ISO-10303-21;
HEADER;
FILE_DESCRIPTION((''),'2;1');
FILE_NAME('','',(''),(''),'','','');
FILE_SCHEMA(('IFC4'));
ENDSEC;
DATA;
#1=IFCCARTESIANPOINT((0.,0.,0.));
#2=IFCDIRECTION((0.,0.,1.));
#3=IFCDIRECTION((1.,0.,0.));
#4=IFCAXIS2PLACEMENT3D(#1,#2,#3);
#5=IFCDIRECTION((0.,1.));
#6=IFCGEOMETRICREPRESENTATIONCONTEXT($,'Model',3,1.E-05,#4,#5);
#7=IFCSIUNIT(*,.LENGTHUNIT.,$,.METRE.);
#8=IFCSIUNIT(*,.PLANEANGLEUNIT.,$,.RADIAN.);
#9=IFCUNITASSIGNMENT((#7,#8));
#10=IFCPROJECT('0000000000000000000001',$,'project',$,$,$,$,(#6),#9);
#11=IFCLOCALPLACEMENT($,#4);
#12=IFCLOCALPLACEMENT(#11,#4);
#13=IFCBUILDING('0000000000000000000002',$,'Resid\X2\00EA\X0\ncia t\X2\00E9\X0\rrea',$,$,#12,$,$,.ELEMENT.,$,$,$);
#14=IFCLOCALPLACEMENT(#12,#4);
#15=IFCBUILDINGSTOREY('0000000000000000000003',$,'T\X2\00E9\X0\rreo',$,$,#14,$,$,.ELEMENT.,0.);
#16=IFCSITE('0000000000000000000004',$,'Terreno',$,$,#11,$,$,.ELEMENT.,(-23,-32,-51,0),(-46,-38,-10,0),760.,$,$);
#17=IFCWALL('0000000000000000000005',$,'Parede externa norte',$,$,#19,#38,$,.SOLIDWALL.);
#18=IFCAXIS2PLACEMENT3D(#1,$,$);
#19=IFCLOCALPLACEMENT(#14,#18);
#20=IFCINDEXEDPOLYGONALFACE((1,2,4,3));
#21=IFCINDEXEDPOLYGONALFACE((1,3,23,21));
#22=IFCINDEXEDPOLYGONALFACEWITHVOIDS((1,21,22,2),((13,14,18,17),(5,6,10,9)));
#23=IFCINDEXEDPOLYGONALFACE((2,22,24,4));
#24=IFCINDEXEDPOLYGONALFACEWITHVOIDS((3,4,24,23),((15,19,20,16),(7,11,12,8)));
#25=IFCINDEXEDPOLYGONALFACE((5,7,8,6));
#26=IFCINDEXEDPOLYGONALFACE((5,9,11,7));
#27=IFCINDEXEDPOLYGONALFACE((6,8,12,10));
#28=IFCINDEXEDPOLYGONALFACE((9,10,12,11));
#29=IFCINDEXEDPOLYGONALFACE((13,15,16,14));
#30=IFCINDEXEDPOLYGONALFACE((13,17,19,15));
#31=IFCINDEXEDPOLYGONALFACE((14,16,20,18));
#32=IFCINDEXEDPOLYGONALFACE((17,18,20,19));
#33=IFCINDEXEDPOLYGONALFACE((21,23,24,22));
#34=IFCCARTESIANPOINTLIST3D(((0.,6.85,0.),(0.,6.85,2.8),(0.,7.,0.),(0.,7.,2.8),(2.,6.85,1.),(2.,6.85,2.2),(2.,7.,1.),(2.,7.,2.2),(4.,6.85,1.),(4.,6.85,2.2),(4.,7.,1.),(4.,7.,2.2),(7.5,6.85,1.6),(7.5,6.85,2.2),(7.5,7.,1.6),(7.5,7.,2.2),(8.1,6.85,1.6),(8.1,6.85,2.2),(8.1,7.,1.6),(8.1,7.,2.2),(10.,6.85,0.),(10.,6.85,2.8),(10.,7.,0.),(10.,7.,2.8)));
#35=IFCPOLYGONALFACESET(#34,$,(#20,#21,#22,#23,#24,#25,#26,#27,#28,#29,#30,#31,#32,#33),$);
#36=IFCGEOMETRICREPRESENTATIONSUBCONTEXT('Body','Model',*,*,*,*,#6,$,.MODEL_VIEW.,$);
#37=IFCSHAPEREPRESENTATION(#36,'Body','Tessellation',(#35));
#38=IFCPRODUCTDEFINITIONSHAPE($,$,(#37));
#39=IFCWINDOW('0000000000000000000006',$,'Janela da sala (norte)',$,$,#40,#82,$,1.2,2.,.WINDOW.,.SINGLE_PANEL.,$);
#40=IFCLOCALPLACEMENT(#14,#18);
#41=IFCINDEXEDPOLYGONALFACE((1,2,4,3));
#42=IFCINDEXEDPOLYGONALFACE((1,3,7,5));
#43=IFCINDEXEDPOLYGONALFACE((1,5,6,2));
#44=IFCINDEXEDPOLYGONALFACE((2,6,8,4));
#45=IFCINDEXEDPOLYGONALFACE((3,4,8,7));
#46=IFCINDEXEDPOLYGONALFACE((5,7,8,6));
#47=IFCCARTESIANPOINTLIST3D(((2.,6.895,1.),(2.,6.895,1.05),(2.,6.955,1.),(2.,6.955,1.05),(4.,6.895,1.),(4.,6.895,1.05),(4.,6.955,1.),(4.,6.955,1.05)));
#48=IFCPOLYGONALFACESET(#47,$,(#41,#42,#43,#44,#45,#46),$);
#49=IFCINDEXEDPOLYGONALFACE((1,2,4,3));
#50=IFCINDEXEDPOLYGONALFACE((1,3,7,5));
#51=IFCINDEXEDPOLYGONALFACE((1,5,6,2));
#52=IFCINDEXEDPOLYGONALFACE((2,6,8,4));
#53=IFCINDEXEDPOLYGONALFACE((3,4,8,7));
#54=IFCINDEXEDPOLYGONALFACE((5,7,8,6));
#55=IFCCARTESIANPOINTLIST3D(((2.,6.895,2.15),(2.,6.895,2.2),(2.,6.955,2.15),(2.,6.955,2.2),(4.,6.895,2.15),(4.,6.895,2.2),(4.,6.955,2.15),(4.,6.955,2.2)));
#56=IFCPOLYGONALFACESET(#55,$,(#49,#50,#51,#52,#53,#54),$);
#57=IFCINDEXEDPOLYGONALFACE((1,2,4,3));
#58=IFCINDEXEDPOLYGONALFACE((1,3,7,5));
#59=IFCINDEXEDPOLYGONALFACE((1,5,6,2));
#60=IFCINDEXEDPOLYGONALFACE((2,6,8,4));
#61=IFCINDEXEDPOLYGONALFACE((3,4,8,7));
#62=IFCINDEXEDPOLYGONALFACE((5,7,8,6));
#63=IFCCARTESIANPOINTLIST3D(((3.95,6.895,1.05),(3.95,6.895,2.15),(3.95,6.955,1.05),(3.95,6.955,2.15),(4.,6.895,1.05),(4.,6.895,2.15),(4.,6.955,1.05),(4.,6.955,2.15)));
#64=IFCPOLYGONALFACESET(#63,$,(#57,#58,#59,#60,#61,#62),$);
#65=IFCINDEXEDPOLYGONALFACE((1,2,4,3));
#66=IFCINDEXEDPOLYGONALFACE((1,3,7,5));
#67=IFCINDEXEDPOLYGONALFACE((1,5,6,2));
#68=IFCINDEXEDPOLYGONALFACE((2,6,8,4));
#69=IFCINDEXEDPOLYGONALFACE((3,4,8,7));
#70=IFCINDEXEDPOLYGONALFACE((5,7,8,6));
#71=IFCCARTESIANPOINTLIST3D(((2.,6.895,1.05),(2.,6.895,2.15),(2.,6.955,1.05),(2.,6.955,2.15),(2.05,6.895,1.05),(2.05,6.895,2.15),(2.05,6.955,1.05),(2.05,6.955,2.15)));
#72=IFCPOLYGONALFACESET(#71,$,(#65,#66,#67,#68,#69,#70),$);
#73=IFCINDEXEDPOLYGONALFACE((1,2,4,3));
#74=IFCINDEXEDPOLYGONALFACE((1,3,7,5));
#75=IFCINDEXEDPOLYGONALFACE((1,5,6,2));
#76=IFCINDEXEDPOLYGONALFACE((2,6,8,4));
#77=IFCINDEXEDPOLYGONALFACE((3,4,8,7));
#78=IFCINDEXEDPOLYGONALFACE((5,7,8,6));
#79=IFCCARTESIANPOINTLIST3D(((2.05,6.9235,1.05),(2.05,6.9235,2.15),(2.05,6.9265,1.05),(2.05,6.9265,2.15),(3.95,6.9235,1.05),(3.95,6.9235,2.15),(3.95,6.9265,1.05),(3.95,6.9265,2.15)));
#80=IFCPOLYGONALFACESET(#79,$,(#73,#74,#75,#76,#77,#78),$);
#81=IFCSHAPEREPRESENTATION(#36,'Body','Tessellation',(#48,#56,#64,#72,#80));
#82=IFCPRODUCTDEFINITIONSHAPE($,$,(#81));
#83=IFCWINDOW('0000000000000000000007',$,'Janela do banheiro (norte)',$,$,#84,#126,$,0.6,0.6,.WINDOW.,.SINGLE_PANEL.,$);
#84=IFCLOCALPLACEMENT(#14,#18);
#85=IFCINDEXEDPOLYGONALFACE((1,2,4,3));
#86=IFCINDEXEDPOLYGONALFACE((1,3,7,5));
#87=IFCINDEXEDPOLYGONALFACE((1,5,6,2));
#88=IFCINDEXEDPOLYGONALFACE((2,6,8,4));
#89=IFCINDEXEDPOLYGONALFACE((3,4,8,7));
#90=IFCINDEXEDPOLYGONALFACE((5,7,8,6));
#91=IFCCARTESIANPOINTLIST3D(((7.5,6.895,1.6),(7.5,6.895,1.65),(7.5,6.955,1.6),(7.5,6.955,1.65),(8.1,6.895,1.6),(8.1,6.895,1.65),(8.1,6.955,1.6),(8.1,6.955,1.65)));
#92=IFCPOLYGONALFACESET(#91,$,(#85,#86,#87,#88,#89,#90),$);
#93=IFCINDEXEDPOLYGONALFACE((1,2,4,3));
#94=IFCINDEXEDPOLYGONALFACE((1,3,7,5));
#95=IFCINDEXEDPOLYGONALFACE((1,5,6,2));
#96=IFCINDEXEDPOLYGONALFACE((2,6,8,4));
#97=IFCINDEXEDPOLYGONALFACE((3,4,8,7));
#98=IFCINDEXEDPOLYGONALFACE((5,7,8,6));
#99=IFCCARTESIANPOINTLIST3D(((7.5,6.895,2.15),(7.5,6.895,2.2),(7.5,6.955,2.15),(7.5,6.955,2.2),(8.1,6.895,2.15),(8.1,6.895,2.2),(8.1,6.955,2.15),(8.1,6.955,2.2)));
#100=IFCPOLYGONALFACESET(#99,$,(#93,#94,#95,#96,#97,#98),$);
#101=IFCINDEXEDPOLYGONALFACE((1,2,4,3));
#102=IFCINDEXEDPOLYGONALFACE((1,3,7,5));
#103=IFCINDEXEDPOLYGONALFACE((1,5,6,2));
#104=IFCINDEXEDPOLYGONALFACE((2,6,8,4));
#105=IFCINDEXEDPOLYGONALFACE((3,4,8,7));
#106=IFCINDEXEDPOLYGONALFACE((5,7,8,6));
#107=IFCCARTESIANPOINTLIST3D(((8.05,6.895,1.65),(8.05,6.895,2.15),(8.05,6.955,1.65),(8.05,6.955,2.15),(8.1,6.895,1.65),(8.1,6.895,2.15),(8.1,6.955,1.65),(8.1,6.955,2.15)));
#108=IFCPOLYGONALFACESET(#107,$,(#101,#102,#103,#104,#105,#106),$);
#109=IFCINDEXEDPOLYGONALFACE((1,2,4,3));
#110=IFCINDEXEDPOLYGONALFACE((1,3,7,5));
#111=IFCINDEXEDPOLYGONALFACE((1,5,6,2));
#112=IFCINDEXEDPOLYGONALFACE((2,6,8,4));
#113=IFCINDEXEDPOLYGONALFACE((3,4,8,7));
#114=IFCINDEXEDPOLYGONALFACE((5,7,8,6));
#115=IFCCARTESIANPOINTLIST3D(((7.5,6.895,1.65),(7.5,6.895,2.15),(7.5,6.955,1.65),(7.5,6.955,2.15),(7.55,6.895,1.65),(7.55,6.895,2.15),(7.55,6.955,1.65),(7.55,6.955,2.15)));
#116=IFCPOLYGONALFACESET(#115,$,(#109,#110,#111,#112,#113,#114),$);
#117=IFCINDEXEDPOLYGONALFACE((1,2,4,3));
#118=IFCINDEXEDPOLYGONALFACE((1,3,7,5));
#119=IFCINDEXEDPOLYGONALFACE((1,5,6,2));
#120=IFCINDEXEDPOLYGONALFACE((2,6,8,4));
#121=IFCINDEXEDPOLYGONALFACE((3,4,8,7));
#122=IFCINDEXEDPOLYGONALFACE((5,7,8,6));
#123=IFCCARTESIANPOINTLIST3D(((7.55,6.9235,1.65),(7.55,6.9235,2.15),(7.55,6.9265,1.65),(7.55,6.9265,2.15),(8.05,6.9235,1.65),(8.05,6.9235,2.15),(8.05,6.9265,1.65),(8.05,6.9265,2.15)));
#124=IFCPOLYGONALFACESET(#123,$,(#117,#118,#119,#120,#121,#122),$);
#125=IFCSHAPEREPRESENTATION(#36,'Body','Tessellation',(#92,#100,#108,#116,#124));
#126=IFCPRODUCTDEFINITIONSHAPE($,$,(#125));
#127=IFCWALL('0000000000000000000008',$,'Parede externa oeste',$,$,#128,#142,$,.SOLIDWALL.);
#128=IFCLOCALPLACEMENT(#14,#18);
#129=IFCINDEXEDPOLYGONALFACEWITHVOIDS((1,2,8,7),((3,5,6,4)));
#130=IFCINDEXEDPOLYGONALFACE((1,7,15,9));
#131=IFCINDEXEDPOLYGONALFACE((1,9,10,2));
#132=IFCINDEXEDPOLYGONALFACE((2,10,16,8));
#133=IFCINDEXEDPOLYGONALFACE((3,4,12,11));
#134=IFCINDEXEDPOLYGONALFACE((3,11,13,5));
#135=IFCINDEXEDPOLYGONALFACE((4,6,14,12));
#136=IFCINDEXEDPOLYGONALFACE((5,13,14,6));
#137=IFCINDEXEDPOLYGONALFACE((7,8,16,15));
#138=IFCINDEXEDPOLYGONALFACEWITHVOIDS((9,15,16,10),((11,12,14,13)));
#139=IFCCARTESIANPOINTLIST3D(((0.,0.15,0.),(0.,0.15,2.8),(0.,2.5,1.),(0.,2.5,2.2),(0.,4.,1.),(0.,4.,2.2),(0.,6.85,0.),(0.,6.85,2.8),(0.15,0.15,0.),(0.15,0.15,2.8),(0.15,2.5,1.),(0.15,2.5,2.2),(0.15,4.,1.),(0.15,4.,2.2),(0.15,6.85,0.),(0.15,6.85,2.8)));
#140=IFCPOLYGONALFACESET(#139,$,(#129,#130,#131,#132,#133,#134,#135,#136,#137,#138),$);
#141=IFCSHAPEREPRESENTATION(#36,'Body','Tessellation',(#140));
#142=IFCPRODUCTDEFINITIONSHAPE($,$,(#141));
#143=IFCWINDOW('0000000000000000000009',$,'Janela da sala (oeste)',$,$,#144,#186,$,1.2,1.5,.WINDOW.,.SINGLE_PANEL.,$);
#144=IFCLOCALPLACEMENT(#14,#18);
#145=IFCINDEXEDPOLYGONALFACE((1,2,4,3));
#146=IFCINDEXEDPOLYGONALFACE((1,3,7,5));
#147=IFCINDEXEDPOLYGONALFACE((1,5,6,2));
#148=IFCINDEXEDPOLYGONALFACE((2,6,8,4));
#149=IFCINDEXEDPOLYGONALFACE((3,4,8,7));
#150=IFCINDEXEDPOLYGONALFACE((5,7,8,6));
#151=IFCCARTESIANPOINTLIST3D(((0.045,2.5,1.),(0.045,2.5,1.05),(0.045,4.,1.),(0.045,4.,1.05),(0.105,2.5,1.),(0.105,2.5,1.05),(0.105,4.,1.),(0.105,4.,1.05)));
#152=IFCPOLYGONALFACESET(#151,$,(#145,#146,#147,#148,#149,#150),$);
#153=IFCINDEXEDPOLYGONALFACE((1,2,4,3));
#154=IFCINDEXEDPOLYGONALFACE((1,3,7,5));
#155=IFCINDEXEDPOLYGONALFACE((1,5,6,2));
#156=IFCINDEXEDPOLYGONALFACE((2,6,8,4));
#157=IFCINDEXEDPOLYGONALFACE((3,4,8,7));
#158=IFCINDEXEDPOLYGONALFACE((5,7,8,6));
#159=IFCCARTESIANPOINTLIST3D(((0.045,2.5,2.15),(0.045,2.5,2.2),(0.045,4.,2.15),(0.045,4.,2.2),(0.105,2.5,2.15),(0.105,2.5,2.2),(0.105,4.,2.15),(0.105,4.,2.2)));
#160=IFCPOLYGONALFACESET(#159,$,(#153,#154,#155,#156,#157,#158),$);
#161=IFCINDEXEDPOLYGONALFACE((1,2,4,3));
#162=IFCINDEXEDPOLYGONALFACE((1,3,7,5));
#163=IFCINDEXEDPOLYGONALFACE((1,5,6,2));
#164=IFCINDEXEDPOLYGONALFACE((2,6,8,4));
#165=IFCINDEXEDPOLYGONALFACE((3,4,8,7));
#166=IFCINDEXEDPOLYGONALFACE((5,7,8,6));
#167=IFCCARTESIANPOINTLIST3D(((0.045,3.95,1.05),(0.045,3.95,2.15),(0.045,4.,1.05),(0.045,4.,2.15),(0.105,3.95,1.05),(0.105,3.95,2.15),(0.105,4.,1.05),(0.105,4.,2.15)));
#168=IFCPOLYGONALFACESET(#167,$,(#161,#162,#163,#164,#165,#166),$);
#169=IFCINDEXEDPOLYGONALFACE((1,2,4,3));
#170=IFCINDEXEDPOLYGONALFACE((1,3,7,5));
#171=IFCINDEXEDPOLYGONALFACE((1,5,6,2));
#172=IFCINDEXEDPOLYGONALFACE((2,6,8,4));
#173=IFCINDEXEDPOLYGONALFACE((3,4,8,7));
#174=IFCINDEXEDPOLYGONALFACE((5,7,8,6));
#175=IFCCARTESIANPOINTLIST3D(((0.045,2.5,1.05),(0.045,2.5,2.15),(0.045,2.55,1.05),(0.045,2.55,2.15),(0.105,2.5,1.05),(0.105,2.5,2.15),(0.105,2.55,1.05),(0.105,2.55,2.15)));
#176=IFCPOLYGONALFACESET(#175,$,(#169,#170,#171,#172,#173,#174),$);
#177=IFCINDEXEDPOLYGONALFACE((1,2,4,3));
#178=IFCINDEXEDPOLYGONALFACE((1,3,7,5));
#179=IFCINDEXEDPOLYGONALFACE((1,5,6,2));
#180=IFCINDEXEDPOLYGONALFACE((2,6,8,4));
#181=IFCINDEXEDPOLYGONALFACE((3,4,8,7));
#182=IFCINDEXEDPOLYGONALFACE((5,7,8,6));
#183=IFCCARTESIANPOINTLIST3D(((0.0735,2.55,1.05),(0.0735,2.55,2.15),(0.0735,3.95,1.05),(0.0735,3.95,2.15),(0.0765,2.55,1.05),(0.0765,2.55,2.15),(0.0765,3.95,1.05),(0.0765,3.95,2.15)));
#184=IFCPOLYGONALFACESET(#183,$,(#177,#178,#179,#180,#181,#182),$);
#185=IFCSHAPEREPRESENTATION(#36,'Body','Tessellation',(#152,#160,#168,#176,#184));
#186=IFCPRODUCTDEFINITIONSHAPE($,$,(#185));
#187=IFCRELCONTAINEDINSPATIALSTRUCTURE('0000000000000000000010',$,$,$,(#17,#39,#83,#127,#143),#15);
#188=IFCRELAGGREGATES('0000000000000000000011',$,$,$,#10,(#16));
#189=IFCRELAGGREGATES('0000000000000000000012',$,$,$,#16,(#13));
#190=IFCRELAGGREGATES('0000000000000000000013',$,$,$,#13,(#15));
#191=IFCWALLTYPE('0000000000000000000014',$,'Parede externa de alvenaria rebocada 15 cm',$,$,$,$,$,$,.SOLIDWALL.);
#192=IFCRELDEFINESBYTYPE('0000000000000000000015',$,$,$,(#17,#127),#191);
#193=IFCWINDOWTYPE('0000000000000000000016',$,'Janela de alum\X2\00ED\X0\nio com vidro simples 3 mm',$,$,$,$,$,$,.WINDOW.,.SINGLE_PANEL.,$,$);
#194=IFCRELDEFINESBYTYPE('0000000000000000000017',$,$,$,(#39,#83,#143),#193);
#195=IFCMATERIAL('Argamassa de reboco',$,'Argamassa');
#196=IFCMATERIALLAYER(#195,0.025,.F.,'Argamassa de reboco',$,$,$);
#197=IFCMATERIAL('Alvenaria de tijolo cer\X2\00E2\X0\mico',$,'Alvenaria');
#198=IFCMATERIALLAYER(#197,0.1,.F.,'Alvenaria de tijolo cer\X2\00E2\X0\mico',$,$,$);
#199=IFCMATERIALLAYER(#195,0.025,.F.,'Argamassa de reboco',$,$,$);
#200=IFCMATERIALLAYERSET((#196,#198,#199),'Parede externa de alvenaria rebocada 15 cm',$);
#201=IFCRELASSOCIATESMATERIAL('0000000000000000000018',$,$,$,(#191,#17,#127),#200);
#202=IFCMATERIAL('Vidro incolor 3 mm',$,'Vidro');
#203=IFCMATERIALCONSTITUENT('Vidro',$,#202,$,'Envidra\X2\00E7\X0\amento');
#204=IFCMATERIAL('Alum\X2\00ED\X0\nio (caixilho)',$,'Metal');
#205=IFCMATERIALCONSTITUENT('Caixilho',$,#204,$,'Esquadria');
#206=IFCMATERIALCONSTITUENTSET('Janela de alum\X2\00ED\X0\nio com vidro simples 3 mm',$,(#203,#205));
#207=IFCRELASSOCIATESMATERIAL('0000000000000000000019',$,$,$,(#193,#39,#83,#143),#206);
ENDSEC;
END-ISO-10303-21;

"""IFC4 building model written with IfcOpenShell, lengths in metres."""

from ifc_helpers import new_model, si_unit, direction, frame, frame_2d, origin_with_axes, place, context, subcontext, project, spatial, rectangle, extrude, material, layer, layer_set, layer_usage, constituent, constituent_set, type_object, element, fill, save


model = new_model("IFC4")

# Units and contexts
model_context = context("Model", 3, precision=1e-05, world=origin_with_axes(), true_north=direction((0.0, 1.0)))
body_context = subcontext(model_context, "Body", "Model", "MODEL_VIEW")
ifc_project = project(units=[si_unit("LENGTHUNIT", "METRE"), si_unit("PLANEANGLEUNIT", "RADIAN")], contexts=[model_context])

# Site, building, storey
site_placement = place(None, origin_with_axes())
site = spatial("IfcSite", under=ifc_project, at=site_placement, Name="Terreno", CompositionType="ELEMENT", RefLatitude=(-23, -32, -51, 0), RefLongitude=(-46, -38, -10, 0), RefElevation=760.0)
building_placement = place(site_placement, origin_with_axes())
building = spatial("IfcBuilding", under=site, at=building_placement, Name="Residência térrea", CompositionType="ELEMENT")
storey_placement = place(building_placement, origin_with_axes())
storey = spatial("IfcBuildingStorey", under=building, at=storey_placement, Name="Térreo", CompositionType="ELEMENT", Elevation=0.0)

# Shared definitions
ifc_material_1 = material(Name="Argamassa de reboco", Category="Argamassa")

# Shared definitions
ifc_layer_1 = layer(ifc_material_1, 0.025, ventilated=False, Name="Argamassa de reboco")
ifc_material_2 = material(Name="Alvenaria de tijolo cerâmico", Category="Alvenaria")
ifc_layer_2 = layer(ifc_material_2, 0.1, ventilated=False, Name="Alvenaria de tijolo cerâmico")
ifc_layer_3 = layer(ifc_material_1, 0.025, ventilated=False, Name="Argamassa de reboco")
ifc_layer_set_1 = layer_set([ifc_layer_1, ifc_layer_2, ifc_layer_3], Name="Parede externa de alvenaria rebocada 15 cm")
wall_type_1 = type_object("IfcWallType", Name="Parede externa de alvenaria rebocada 15 cm", PredefinedType="SOLIDWALL", material=ifc_layer_set_1)
ifc_material_3 = material(Name="Vidro incolor 3 mm", Category="Vidro")
ifc_constituent_1 = constituent(ifc_material_3, Name="Vidro", Category="Envidraçamento")
ifc_material_4 = material(Name="Alumínio (caixilho)", Category="Metal")
ifc_constituent_2 = constituent(ifc_material_4, Name="Caixilho", Category="Esquadria")
ifc_constituent_set = constituent_set(constituents=[ifc_constituent_1, ifc_constituent_2], Name="Janela de alumínio com vidro simples 3 mm")
window_type = type_object("IfcWindowType", Name="Janela de alumínio com vidro simples 3 mm", PartitioningType="SINGLE_PANEL", PredefinedType="WINDOW", material=ifc_constituent_set)

# Wall, openings, windows
ifc_layer_usage_1 = layer_usage(ifc_layer_set_1, "AXIS2", "POSITIVE", 0.0)
wall_1_placement = place(storey_placement, frame((10.0, 7.0, 0.0), z_axis=(0.0, 0.0, 1.0), x_axis=(-1.0, 0.0, 0.0)))
wall_1 = element("IfcWall", 1, at=wall_1_placement, inside=storey, type_object=wall_type_1, material=ifc_layer_usage_1, Name="Parede externa norte", PredefinedType="SOLIDWALL", context=body_context, shape_type="SweptSolid", body=[
    extrude(rectangle(XDim=10.0, YDim=0.15, at=frame_2d((5.0, 0.075))), origin_with_axes(), (0.0, 0.0, 1.0), 2.8),
])
opening_1_placement = place(wall_1_placement, frame((6.0, 0.0, 1.0), z_axis=(0.0, 0.0, 1.0), x_axis=(1.0, 0.0, 0.0)))
opening_1 = element("IfcOpeningElement", 2, at=opening_1_placement, cuts=wall_1, PredefinedType="OPENING", context=body_context, shape_type="SweptSolid", body=[
    extrude(rectangle(XDim=2.0, YDim=0.25, at=frame_2d((1.0, 0.075))), origin_with_axes(), (0.0, 0.0, 1.0), 1.2),
])
opening_2_placement = place(wall_1_placement, frame((1.9, 0.0, 1.6), z_axis=(0.0, 0.0, 1.0), x_axis=(1.0, 0.0, 0.0)))
opening_2 = element("IfcOpeningElement", 3, at=opening_2_placement, cuts=wall_1, PredefinedType="OPENING", context=body_context, shape_type="SweptSolid", body=[
    extrude(rectangle(XDim=0.6, YDim=0.25, at=frame_2d((0.3, 0.075))), origin_with_axes(), (0.0, 0.0, 1.0), 0.6),
])
window_1_placement = place(opening_1_placement, origin_with_axes())
window_1 = element("IfcWindow", 4, at=window_1_placement, inside=storey, type_object=window_type, material=ifc_constituent_set, Name="Janela da sala (norte)", OverallHeight=1.2, OverallWidth=2.0, PartitioningType="SINGLE_PANEL", PredefinedType="WINDOW", context=body_context, shape_type="SweptSolid", body=[
    extrude(rectangle(XDim=2.0, YDim=0.06, at=frame_2d((1.0, 0.075))), origin_with_axes(), (0.0, 0.0, 1.0), 0.05),
    extrude(rectangle(XDim=2.0, YDim=0.06, at=frame_2d((1.0, 0.075))), frame((0.0, 0.0, 1.15), z_axis=(0.0, 0.0, 1.0), x_axis=(1.0, 0.0, 0.0)), (0.0, 0.0, 1.0), 0.05),
    extrude(rectangle(XDim=0.05, YDim=0.06, at=frame_2d((0.025, 0.075))), frame((0.0, 0.0, 0.05), z_axis=(0.0, 0.0, 1.0), x_axis=(1.0, 0.0, 0.0)), (0.0, 0.0, 1.0), 1.1),
    extrude(rectangle(XDim=0.05, YDim=0.06, at=frame_2d((1.975, 0.075))), frame((0.0, 0.0, 0.05), z_axis=(0.0, 0.0, 1.0), x_axis=(1.0, 0.0, 0.0)), (0.0, 0.0, 1.0), 1.1),
    extrude(rectangle(XDim=1.9, YDim=0.003, at=frame_2d((1.0, 0.075))), frame((0.0, 0.0, 0.05), z_axis=(0.0, 0.0, 1.0), x_axis=(1.0, 0.0, 0.0)), (0.0, 0.0, 1.0), 1.1),
])
fill(opening_1, window_1)
window_2_placement = place(opening_2_placement, origin_with_axes())
window_2 = element("IfcWindow", 5, at=window_2_placement, inside=storey, type_object=window_type, material=ifc_constituent_set, Name="Janela do banheiro (norte)", OverallHeight=0.6, OverallWidth=0.6, PartitioningType="SINGLE_PANEL", PredefinedType="WINDOW", context=body_context, shape_type="SweptSolid", body=[
    extrude(rectangle(XDim=0.6, YDim=0.06, at=frame_2d((0.3, 0.075))), origin_with_axes(), (0.0, 0.0, 1.0), 0.05),
    extrude(rectangle(XDim=0.6, YDim=0.06, at=frame_2d((0.3, 0.075))), frame((0.0, 0.0, 0.55), z_axis=(0.0, 0.0, 1.0), x_axis=(1.0, 0.0, 0.0)), (0.0, 0.0, 1.0), 0.05),
    extrude(rectangle(XDim=0.05, YDim=0.06, at=frame_2d((0.025, 0.075))), frame((0.0, 0.0, 0.05), z_axis=(0.0, 0.0, 1.0), x_axis=(1.0, 0.0, 0.0)), (0.0, 0.0, 1.0), 0.5),
    extrude(rectangle(XDim=0.05, YDim=0.06, at=frame_2d((0.575, 0.075))), frame((0.0, 0.0, 0.05), z_axis=(0.0, 0.0, 1.0), x_axis=(1.0, 0.0, 0.0)), (0.0, 0.0, 1.0), 0.5),
    extrude(rectangle(XDim=0.5, YDim=0.003, at=frame_2d((0.3, 0.075))), frame((0.0, 0.0, 0.05), z_axis=(0.0, 0.0, 1.0), x_axis=(1.0, 0.0, 0.0)), (0.0, 0.0, 1.0), 0.5),
])
fill(opening_2, window_2)

# Wall, opening, window
ifc_layer_usage_2 = layer_usage(ifc_layer_set_1, "AXIS2", "POSITIVE", 0.0)
wall_2_placement = place(storey_placement, frame((0.0, 6.85, 0.0), z_axis=(0.0, 0.0, 1.0), x_axis=(0.0, -1.0, 0.0)))
wall_2 = element("IfcWall", 6, at=wall_2_placement, inside=storey, type_object=wall_type_1, material=ifc_layer_usage_2, Name="Parede externa oeste", PredefinedType="SOLIDWALL", context=body_context, shape_type="SweptSolid", body=[
    extrude(rectangle(XDim=6.7, YDim=0.15, at=frame_2d((3.35, 0.075))), origin_with_axes(), (0.0, 0.0, 1.0), 2.8),
])
opening_3_placement = place(wall_2_placement, frame((2.85, 0.0, 1.0), z_axis=(0.0, 0.0, 1.0), x_axis=(1.0, 0.0, 0.0)))
opening_3 = element("IfcOpeningElement", 7, at=opening_3_placement, cuts=wall_2, PredefinedType="OPENING", context=body_context, shape_type="SweptSolid", body=[
    extrude(rectangle(XDim=1.5, YDim=0.25, at=frame_2d((0.75, 0.075))), origin_with_axes(), (0.0, 0.0, 1.0), 1.2),
])
window_3_placement = place(opening_3_placement, origin_with_axes())
window_3 = element("IfcWindow", 8, at=window_3_placement, inside=storey, type_object=window_type, material=ifc_constituent_set, Name="Janela da sala (oeste)", OverallHeight=1.2, OverallWidth=1.5, PartitioningType="SINGLE_PANEL", PredefinedType="WINDOW", context=body_context, shape_type="SweptSolid", body=[
    extrude(rectangle(XDim=1.5, YDim=0.06, at=frame_2d((0.75, 0.075))), origin_with_axes(), (0.0, 0.0, 1.0), 0.05),
    extrude(rectangle(XDim=1.5, YDim=0.06, at=frame_2d((0.75, 0.075))), frame((0.0, 0.0, 1.15), z_axis=(0.0, 0.0, 1.0), x_axis=(1.0, 0.0, 0.0)), (0.0, 0.0, 1.0), 0.05),
    extrude(rectangle(XDim=0.05, YDim=0.06, at=frame_2d((0.025, 0.075))), frame((0.0, 0.0, 0.05), z_axis=(0.0, 0.0, 1.0), x_axis=(1.0, 0.0, 0.0)), (0.0, 0.0, 1.0), 1.1),
    extrude(rectangle(XDim=0.05, YDim=0.06, at=frame_2d((1.475, 0.075))), frame((0.0, 0.0, 0.05), z_axis=(0.0, 0.0, 1.0), x_axis=(1.0, 0.0, 0.0)), (0.0, 0.0, 1.0), 1.1),
    extrude(rectangle(XDim=1.4, YDim=0.003, at=frame_2d((0.75, 0.075))), frame((0.0, 0.0, 0.05), z_axis=(0.0, 0.0, 1.0), x_axis=(1.0, 0.0, 0.0)), (0.0, 0.0, 1.0), 1.1),
])
fill(opening_3, window_3)

save(model, "model.ifc")
